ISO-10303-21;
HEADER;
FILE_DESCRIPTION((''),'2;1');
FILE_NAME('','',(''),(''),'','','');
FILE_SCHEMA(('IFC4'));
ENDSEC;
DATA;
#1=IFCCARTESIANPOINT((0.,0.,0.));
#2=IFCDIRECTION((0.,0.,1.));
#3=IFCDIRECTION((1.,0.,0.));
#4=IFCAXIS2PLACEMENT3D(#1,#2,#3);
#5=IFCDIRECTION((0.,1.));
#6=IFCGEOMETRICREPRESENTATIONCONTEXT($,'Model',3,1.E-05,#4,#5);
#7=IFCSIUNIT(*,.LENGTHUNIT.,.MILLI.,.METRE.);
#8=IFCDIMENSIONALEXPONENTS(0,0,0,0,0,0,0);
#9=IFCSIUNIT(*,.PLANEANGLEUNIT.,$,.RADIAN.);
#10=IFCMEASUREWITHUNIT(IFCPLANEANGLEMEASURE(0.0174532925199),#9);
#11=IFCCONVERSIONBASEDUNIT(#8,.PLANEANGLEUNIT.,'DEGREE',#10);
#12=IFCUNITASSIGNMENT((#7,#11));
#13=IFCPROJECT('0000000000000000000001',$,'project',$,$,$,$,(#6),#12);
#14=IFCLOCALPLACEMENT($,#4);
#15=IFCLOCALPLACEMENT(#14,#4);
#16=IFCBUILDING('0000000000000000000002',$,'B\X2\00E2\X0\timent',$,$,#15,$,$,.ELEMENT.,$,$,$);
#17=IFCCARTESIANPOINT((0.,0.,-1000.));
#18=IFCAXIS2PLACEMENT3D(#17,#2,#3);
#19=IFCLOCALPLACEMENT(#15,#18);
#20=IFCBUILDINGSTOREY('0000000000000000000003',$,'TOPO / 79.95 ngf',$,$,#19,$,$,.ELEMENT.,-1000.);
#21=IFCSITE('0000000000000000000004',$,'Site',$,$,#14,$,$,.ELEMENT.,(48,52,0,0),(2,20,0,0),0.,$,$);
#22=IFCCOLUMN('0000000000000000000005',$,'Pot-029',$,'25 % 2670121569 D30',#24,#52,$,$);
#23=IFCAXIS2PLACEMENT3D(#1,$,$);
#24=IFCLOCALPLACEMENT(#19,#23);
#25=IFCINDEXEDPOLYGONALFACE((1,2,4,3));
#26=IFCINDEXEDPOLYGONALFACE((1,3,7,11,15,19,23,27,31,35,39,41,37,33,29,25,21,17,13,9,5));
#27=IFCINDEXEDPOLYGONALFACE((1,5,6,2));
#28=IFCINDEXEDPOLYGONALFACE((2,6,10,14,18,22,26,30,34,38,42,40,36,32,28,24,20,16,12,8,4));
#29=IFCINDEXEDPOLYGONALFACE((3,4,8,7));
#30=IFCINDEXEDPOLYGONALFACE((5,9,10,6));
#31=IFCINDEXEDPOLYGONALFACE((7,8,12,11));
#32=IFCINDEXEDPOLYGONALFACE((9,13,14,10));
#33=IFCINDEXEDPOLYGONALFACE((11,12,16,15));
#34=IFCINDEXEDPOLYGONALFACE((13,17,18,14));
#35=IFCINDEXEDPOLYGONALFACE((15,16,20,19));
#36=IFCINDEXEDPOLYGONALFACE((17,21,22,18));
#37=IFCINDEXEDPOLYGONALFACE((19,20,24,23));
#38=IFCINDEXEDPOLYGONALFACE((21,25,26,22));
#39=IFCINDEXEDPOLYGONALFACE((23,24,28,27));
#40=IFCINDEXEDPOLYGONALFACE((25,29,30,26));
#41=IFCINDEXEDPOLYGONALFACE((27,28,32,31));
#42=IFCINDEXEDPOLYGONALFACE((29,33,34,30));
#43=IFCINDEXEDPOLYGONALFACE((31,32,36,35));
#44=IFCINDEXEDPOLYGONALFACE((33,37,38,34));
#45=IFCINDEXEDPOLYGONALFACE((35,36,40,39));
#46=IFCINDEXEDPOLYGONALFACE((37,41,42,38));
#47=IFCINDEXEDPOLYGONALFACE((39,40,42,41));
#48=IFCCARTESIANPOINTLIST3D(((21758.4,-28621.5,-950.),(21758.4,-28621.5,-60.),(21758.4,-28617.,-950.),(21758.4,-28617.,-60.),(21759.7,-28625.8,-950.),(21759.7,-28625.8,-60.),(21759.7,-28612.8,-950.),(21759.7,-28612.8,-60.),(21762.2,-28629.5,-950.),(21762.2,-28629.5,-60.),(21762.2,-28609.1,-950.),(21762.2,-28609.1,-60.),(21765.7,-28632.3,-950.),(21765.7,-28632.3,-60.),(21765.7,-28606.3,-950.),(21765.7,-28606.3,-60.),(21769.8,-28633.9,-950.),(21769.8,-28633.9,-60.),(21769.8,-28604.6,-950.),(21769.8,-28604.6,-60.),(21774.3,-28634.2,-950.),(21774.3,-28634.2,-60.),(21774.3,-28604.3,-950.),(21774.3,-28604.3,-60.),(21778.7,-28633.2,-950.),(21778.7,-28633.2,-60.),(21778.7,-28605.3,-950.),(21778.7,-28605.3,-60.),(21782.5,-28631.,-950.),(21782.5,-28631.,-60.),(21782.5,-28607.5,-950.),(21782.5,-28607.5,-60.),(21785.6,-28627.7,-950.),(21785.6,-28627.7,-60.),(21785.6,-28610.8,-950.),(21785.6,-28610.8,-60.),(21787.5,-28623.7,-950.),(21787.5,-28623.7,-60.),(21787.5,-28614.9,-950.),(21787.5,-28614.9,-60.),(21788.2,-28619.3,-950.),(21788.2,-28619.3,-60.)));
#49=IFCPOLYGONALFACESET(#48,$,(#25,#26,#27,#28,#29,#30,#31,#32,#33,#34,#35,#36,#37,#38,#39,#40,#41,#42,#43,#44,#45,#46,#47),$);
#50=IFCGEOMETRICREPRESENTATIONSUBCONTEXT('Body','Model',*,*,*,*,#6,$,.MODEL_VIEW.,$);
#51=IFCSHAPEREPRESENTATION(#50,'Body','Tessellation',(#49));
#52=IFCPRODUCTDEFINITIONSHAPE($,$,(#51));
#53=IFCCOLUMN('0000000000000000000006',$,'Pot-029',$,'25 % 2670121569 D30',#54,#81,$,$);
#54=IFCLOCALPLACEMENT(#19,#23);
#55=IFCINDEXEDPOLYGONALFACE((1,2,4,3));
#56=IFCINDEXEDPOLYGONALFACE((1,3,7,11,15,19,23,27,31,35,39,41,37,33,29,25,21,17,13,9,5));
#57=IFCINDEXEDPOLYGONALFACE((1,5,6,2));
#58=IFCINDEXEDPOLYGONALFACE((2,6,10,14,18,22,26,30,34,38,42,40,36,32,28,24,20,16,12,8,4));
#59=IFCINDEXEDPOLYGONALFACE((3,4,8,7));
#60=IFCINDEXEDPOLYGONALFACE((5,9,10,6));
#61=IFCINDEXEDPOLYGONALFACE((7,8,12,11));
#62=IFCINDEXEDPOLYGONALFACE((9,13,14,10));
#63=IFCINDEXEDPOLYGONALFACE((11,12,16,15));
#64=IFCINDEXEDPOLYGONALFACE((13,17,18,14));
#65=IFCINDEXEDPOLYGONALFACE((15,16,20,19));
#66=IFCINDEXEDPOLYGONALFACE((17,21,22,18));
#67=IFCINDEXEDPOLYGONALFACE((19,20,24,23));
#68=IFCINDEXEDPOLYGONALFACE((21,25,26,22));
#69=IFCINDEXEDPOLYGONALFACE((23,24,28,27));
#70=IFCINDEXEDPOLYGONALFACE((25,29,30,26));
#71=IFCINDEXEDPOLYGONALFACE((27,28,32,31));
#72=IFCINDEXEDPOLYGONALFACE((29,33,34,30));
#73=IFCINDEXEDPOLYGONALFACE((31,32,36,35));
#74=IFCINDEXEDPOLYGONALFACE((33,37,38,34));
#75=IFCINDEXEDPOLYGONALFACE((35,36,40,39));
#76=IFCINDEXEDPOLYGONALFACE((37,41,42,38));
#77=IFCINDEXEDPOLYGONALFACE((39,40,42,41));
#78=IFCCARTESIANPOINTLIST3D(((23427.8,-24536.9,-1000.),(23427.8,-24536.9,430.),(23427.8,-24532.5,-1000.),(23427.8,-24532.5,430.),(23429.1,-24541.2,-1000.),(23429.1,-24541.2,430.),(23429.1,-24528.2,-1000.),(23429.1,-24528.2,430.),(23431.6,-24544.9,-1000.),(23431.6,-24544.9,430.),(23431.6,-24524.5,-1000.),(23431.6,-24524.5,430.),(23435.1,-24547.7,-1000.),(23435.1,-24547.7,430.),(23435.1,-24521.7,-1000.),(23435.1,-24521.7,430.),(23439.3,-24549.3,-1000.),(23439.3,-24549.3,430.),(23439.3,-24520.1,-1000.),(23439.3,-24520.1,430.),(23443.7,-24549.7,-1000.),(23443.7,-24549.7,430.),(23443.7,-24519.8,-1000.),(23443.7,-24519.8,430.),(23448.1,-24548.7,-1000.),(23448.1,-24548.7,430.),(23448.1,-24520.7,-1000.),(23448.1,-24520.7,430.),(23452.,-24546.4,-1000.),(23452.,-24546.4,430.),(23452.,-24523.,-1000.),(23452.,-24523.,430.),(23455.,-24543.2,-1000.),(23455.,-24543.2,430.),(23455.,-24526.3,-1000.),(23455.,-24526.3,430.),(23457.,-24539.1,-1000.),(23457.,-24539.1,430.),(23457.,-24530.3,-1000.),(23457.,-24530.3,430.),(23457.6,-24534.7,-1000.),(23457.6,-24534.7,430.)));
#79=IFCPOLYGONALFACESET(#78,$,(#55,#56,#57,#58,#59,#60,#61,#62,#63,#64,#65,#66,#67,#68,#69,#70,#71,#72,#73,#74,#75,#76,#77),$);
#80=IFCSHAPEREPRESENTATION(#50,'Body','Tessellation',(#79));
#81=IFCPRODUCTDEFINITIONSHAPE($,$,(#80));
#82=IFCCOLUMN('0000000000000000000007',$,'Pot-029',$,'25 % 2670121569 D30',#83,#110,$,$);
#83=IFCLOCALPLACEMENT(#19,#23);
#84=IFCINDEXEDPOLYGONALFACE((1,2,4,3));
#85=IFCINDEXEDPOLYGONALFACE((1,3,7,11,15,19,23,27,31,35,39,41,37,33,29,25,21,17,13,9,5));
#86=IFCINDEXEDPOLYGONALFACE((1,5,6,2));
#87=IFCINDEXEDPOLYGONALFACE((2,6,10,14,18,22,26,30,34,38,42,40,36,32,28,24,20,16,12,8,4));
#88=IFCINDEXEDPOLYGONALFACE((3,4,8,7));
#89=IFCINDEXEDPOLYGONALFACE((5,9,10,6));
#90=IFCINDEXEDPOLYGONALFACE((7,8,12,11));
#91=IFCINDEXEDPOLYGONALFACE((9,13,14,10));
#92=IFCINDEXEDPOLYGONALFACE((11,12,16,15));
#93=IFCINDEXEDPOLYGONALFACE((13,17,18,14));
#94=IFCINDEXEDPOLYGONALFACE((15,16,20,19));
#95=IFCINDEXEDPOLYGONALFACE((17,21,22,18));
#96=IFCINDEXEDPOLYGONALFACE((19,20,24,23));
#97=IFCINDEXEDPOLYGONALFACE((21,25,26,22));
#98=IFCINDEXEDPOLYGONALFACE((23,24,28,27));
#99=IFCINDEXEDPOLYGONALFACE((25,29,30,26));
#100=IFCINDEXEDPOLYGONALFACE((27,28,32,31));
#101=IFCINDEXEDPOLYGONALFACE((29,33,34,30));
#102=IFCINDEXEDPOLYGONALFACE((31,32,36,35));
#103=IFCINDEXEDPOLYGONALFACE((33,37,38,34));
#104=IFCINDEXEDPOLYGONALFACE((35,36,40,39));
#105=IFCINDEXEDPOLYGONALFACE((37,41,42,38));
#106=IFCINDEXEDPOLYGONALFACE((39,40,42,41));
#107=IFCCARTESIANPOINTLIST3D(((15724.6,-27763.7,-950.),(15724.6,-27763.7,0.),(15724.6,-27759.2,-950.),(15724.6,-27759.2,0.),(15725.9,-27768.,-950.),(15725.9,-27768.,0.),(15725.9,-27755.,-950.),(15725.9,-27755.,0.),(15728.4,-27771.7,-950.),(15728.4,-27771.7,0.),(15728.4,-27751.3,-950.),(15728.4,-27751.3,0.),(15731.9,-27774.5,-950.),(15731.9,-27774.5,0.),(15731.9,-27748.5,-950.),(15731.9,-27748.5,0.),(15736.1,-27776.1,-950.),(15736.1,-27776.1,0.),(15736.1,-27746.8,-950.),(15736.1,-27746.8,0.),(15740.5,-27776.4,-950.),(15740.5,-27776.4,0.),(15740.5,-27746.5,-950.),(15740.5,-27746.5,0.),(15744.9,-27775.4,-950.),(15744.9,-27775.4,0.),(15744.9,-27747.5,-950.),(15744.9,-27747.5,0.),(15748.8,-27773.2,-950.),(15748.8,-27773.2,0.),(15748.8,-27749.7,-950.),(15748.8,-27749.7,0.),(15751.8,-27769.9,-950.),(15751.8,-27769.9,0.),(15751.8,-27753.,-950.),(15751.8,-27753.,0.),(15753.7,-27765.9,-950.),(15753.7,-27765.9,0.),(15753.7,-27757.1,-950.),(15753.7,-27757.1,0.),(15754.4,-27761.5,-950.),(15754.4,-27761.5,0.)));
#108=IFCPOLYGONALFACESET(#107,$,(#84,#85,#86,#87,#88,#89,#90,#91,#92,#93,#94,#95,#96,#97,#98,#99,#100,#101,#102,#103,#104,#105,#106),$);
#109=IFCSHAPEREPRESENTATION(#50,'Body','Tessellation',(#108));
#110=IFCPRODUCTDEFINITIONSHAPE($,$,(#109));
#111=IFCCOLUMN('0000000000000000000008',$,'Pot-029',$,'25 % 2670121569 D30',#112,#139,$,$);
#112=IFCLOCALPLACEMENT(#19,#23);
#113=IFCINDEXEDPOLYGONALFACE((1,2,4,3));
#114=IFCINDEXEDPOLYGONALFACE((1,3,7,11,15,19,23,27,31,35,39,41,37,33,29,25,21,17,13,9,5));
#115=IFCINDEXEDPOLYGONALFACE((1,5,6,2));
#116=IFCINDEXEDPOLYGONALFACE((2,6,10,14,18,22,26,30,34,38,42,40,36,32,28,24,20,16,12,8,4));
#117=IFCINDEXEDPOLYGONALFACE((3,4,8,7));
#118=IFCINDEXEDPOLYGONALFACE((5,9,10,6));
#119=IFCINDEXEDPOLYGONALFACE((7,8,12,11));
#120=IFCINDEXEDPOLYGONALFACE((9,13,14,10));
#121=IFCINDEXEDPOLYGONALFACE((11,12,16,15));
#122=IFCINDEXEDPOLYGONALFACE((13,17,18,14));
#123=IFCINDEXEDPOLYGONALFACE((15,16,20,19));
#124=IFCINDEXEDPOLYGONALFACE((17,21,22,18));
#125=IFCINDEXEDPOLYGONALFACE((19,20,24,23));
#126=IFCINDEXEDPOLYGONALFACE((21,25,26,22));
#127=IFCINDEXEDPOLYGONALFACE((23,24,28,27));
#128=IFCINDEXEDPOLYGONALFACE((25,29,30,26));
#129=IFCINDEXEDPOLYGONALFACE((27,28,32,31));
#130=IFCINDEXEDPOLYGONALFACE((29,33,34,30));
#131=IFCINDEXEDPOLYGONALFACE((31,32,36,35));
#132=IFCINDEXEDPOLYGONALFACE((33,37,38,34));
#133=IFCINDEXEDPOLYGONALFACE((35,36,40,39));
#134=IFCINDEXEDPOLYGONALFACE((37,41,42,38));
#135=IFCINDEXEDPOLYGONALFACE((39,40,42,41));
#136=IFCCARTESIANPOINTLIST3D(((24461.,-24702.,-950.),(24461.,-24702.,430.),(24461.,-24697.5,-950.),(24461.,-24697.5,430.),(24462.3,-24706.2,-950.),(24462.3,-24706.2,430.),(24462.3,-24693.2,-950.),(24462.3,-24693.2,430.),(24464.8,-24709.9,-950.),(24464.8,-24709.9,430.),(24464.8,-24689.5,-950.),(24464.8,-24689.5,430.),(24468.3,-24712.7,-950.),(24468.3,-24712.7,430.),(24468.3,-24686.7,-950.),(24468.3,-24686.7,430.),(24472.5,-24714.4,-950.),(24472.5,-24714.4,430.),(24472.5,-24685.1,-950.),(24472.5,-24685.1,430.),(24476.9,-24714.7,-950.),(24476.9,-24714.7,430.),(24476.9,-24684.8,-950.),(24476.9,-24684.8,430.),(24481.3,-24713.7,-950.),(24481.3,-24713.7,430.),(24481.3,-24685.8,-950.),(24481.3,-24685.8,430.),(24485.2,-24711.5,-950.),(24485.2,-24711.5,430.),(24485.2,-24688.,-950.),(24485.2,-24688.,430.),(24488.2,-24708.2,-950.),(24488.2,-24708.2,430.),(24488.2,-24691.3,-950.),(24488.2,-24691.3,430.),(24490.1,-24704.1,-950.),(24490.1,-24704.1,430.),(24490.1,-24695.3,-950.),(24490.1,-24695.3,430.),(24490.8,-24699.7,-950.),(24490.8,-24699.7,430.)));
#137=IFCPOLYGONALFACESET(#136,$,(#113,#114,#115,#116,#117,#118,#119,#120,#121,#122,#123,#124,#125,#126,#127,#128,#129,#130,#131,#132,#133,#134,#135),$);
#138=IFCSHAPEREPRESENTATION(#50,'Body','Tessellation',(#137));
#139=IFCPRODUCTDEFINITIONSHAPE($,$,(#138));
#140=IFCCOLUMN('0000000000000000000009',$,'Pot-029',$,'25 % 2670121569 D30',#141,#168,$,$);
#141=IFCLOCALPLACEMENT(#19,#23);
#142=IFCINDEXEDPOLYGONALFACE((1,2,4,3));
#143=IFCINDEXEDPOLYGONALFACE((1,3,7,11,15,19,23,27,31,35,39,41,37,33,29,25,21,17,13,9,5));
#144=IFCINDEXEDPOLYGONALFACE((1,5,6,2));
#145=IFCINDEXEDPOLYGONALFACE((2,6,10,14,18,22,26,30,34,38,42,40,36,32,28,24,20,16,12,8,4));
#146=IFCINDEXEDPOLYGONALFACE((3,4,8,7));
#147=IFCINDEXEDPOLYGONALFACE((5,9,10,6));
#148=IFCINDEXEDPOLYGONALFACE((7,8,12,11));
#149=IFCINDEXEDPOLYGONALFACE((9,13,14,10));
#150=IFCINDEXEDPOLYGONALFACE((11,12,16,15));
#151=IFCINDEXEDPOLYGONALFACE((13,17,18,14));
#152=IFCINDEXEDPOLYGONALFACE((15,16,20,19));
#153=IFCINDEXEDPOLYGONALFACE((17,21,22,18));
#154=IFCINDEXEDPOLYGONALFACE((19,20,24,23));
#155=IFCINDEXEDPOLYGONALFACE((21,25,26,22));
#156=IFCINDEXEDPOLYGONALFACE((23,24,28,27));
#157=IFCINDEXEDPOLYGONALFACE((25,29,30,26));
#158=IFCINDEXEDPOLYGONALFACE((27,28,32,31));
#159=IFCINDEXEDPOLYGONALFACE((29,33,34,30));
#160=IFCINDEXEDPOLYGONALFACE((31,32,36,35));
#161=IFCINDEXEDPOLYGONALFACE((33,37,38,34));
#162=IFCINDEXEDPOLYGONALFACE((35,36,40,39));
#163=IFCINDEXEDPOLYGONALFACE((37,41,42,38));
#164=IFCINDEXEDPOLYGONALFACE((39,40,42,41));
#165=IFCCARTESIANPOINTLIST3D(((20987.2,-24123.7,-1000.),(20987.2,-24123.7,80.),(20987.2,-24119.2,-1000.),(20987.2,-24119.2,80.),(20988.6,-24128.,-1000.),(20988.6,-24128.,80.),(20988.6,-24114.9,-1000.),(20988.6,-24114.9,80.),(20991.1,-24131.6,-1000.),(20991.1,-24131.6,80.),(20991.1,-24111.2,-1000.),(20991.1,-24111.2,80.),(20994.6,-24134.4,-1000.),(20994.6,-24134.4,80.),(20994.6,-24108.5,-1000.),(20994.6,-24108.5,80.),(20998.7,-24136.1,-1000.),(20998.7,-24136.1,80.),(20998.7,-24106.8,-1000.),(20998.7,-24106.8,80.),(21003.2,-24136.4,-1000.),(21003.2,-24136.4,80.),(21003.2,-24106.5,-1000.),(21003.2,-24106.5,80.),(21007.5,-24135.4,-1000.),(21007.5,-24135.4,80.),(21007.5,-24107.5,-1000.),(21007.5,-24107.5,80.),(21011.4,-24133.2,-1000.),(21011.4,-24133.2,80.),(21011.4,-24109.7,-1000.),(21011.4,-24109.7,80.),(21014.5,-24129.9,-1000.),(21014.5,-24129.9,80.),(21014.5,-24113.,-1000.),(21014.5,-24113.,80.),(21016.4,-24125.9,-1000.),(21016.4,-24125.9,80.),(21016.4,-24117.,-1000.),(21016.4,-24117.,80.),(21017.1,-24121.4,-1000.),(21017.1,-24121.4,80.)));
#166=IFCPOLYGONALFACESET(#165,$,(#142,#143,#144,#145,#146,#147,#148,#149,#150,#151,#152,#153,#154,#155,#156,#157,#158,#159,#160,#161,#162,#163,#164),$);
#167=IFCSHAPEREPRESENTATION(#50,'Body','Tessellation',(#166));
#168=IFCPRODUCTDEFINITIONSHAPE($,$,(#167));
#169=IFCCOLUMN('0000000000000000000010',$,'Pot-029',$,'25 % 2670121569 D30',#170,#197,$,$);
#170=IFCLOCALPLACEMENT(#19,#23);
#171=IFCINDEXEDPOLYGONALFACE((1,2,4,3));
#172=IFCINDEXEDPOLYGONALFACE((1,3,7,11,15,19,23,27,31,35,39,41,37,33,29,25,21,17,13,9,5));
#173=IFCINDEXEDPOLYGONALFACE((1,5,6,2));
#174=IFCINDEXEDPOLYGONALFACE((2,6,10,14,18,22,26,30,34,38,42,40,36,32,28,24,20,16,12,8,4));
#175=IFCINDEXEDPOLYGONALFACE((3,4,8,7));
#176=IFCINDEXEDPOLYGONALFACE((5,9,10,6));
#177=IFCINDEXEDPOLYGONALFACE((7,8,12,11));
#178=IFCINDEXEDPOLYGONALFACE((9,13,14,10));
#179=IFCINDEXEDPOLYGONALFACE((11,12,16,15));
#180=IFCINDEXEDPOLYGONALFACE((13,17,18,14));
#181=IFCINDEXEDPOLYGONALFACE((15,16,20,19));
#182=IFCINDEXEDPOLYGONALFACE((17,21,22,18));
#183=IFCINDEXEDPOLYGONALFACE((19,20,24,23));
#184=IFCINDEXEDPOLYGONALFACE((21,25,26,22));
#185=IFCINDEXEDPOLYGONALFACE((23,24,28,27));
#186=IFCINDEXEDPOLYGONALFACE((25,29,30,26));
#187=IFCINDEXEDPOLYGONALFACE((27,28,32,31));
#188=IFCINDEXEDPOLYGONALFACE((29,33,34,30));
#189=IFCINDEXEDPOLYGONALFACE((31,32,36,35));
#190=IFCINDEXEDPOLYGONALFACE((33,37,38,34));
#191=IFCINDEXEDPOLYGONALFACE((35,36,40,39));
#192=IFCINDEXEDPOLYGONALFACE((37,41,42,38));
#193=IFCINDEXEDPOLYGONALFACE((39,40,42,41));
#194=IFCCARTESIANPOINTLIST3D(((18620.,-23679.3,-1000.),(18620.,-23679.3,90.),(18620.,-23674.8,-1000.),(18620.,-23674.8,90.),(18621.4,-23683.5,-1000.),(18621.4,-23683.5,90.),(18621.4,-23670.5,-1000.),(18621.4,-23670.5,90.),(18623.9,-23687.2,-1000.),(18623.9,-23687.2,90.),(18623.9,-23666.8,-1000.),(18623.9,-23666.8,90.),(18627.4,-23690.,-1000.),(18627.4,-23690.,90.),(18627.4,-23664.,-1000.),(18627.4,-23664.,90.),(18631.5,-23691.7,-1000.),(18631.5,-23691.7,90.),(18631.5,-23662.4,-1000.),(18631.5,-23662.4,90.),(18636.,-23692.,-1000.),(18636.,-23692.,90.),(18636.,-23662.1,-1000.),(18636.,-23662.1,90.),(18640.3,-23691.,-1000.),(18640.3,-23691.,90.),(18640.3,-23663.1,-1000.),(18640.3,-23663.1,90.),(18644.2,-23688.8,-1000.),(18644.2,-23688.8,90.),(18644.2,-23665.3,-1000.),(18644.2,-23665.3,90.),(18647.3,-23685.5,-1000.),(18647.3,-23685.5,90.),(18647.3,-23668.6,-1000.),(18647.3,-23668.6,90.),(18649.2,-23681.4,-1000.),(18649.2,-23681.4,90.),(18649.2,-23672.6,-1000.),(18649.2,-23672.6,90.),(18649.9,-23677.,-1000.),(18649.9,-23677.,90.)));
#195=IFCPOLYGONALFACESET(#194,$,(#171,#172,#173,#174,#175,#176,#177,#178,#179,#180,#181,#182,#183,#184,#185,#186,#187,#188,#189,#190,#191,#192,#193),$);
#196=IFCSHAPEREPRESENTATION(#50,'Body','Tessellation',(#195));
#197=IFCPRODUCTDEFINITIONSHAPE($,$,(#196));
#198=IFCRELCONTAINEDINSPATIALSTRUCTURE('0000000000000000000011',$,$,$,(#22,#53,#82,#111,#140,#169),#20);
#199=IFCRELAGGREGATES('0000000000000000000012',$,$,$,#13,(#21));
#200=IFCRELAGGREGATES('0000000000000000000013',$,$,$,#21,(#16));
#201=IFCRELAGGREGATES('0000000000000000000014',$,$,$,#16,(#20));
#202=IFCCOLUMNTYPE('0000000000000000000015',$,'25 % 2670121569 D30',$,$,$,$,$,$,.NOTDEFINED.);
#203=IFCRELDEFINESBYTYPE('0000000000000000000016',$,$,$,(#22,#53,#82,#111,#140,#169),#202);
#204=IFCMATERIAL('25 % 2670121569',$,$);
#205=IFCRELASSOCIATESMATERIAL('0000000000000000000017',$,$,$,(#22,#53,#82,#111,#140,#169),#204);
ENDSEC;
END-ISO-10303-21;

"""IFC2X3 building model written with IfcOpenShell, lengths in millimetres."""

from ifc_helpers import new_model, entity, si_unit, converted_unit, direction, frame, origin_with_axes, origin_2d_with_axis, place, context, subcontext, project, spatial, circle, extrude, material, type_object, element, save


model = new_model("IFC2X3")

# Units and contexts
model_context = context("Model", 3, precision=1e-05, world=origin_with_axes(), true_north=direction((0.0, 1.0)))
body_context = subcontext(model_context, "Body", "Model", "MODEL_VIEW")
ifc_project = project(units=[si_unit("LENGTHUNIT", "METRE", prefix="MILLI"), converted_unit("PLANEANGLEUNIT", "DEGREE", entity("IfcPlaneAngleMeasure", 0.0174532925199), si_unit("PLANEANGLEUNIT", "RADIAN"), dimensions=[0, 0, 0, 0, 0, 0, 0])], contexts=[model_context])

# Site, building, storey
site_placement = place(None, origin_with_axes())
site = spatial("IfcSite", under=ifc_project, at=site_placement, Name="Site", CompositionType="ELEMENT", RefLatitude=(48, 52, 0, 0), RefLongitude=(2, 20, 0, 0), RefElevation=0.0)
building_placement = place(site_placement, origin_with_axes())
building = spatial("IfcBuilding", under=site, at=building_placement, Name="Bâtiment", CompositionType="ELEMENT")
storey_placement = place(building_placement, frame((0.0, 0.0, -1000.0), z_axis=(0.0, 0.0, 1.0), x_axis=(1.0, 0.0, 0.0)))
storey = spatial("IfcBuildingStorey", under=building, at=storey_placement, Name="TOPO / 79.95 ngf", CompositionType="ELEMENT", Elevation=-1000.0)

# Columns
ifc_material_1 = material(Name="25 % 2670121569")
column_type = type_object("IfcColumnType", Name="25 % 2670121569 D30", PredefinedType="NOTDEFINED")
column_1_placement = place(storey_placement, frame((21773.2, -28619.3, -950.0), z_axis=(0.0, 0.0, 1.0), x_axis=(1.0, 0.0, 0.0)))
element("IfcColumn", 1, at=column_1_placement, inside=storey, type_object=column_type, material=ifc_material_1, Name="Pot-029", ObjectType="25 % 2670121569 D30", context=body_context, shape_type="SweptSolid", body=[
    extrude(circle(Radius=15.0, at=origin_2d_with_axis()), origin_with_axes(), (0.0, 0.0, 1.0), 890.0),
])
column_2_placement = place(storey_placement, frame((23442.6, -24534.7, -1000.0), z_axis=(0.0, 0.0, 1.0), x_axis=(1.0, 0.0, 0.0)))
element("IfcColumn", 2, at=column_2_placement, inside=storey, type_object=column_type, material=ifc_material_1, Name="Pot-029", ObjectType="25 % 2670121569 D30", context=body_context, shape_type="SweptSolid", body=[
    extrude(circle(Radius=15.0, at=origin_2d_with_axis()), origin_with_axes(), (0.0, 0.0, 1.0), 1430.0),
])
column_3_placement = place(storey_placement, frame((15739.4, -27761.5, -950.0), z_axis=(0.0, 0.0, 1.0), x_axis=(1.0, 0.0, 0.0)))
element("IfcColumn", 3, at=column_3_placement, inside=storey, type_object=column_type, material=ifc_material_1, Name="Pot-029", ObjectType="25 % 2670121569 D30", context=body_context, shape_type="SweptSolid", body=[
    extrude(circle(Radius=15.0, at=origin_2d_with_axis()), origin_with_axes(), (0.0, 0.0, 1.0), 950.0),
])
column_4_placement = place(storey_placement, frame((24475.8, -24699.7, -950.0), z_axis=(0.0, 0.0, 1.0), x_axis=(1.0, 0.0, 0.0)))
element("IfcColumn", 4, at=column_4_placement, inside=storey, type_object=column_type, material=ifc_material_1, Name="Pot-029", ObjectType="25 % 2670121569 D30", context=body_context, shape_type="SweptSolid", body=[
    extrude(circle(Radius=15.0, at=origin_2d_with_axis()), origin_with_axes(), (0.0, 0.0, 1.0), 1380.0),
])
column_5_placement = place(storey_placement, frame((21002.1, -24121.4, -1000.0), z_axis=(0.0, 0.0, 1.0), x_axis=(1.0, 0.0, 0.0)))
element("IfcColumn", 5, at=column_5_placement, inside=storey, type_object=column_type, material=ifc_material_1, Name="Pot-029", ObjectType="25 % 2670121569 D30", context=body_context, shape_type="SweptSolid", body=[
    extrude(circle(Radius=15.0, at=origin_2d_with_axis()), origin_with_axes(), (0.0, 0.0, 1.0), 1080.0),
])
column_6_placement = place(storey_placement, frame((18634.9, -23677.0, -1000.0), z_axis=(0.0, 0.0, 1.0), x_axis=(1.0, 0.0, 0.0)))
element("IfcColumn", 6, at=column_6_placement, inside=storey, type_object=column_type, material=ifc_material_1, Name="Pot-029", ObjectType="25 % 2670121569 D30", context=body_context, shape_type="SweptSolid", body=[
    extrude(circle(Radius=15.0, at=origin_2d_with_axis()), origin_with_axes(), (0.0, 0.0, 1.0), 1090.0),
])

save(model, "model.ifc")
